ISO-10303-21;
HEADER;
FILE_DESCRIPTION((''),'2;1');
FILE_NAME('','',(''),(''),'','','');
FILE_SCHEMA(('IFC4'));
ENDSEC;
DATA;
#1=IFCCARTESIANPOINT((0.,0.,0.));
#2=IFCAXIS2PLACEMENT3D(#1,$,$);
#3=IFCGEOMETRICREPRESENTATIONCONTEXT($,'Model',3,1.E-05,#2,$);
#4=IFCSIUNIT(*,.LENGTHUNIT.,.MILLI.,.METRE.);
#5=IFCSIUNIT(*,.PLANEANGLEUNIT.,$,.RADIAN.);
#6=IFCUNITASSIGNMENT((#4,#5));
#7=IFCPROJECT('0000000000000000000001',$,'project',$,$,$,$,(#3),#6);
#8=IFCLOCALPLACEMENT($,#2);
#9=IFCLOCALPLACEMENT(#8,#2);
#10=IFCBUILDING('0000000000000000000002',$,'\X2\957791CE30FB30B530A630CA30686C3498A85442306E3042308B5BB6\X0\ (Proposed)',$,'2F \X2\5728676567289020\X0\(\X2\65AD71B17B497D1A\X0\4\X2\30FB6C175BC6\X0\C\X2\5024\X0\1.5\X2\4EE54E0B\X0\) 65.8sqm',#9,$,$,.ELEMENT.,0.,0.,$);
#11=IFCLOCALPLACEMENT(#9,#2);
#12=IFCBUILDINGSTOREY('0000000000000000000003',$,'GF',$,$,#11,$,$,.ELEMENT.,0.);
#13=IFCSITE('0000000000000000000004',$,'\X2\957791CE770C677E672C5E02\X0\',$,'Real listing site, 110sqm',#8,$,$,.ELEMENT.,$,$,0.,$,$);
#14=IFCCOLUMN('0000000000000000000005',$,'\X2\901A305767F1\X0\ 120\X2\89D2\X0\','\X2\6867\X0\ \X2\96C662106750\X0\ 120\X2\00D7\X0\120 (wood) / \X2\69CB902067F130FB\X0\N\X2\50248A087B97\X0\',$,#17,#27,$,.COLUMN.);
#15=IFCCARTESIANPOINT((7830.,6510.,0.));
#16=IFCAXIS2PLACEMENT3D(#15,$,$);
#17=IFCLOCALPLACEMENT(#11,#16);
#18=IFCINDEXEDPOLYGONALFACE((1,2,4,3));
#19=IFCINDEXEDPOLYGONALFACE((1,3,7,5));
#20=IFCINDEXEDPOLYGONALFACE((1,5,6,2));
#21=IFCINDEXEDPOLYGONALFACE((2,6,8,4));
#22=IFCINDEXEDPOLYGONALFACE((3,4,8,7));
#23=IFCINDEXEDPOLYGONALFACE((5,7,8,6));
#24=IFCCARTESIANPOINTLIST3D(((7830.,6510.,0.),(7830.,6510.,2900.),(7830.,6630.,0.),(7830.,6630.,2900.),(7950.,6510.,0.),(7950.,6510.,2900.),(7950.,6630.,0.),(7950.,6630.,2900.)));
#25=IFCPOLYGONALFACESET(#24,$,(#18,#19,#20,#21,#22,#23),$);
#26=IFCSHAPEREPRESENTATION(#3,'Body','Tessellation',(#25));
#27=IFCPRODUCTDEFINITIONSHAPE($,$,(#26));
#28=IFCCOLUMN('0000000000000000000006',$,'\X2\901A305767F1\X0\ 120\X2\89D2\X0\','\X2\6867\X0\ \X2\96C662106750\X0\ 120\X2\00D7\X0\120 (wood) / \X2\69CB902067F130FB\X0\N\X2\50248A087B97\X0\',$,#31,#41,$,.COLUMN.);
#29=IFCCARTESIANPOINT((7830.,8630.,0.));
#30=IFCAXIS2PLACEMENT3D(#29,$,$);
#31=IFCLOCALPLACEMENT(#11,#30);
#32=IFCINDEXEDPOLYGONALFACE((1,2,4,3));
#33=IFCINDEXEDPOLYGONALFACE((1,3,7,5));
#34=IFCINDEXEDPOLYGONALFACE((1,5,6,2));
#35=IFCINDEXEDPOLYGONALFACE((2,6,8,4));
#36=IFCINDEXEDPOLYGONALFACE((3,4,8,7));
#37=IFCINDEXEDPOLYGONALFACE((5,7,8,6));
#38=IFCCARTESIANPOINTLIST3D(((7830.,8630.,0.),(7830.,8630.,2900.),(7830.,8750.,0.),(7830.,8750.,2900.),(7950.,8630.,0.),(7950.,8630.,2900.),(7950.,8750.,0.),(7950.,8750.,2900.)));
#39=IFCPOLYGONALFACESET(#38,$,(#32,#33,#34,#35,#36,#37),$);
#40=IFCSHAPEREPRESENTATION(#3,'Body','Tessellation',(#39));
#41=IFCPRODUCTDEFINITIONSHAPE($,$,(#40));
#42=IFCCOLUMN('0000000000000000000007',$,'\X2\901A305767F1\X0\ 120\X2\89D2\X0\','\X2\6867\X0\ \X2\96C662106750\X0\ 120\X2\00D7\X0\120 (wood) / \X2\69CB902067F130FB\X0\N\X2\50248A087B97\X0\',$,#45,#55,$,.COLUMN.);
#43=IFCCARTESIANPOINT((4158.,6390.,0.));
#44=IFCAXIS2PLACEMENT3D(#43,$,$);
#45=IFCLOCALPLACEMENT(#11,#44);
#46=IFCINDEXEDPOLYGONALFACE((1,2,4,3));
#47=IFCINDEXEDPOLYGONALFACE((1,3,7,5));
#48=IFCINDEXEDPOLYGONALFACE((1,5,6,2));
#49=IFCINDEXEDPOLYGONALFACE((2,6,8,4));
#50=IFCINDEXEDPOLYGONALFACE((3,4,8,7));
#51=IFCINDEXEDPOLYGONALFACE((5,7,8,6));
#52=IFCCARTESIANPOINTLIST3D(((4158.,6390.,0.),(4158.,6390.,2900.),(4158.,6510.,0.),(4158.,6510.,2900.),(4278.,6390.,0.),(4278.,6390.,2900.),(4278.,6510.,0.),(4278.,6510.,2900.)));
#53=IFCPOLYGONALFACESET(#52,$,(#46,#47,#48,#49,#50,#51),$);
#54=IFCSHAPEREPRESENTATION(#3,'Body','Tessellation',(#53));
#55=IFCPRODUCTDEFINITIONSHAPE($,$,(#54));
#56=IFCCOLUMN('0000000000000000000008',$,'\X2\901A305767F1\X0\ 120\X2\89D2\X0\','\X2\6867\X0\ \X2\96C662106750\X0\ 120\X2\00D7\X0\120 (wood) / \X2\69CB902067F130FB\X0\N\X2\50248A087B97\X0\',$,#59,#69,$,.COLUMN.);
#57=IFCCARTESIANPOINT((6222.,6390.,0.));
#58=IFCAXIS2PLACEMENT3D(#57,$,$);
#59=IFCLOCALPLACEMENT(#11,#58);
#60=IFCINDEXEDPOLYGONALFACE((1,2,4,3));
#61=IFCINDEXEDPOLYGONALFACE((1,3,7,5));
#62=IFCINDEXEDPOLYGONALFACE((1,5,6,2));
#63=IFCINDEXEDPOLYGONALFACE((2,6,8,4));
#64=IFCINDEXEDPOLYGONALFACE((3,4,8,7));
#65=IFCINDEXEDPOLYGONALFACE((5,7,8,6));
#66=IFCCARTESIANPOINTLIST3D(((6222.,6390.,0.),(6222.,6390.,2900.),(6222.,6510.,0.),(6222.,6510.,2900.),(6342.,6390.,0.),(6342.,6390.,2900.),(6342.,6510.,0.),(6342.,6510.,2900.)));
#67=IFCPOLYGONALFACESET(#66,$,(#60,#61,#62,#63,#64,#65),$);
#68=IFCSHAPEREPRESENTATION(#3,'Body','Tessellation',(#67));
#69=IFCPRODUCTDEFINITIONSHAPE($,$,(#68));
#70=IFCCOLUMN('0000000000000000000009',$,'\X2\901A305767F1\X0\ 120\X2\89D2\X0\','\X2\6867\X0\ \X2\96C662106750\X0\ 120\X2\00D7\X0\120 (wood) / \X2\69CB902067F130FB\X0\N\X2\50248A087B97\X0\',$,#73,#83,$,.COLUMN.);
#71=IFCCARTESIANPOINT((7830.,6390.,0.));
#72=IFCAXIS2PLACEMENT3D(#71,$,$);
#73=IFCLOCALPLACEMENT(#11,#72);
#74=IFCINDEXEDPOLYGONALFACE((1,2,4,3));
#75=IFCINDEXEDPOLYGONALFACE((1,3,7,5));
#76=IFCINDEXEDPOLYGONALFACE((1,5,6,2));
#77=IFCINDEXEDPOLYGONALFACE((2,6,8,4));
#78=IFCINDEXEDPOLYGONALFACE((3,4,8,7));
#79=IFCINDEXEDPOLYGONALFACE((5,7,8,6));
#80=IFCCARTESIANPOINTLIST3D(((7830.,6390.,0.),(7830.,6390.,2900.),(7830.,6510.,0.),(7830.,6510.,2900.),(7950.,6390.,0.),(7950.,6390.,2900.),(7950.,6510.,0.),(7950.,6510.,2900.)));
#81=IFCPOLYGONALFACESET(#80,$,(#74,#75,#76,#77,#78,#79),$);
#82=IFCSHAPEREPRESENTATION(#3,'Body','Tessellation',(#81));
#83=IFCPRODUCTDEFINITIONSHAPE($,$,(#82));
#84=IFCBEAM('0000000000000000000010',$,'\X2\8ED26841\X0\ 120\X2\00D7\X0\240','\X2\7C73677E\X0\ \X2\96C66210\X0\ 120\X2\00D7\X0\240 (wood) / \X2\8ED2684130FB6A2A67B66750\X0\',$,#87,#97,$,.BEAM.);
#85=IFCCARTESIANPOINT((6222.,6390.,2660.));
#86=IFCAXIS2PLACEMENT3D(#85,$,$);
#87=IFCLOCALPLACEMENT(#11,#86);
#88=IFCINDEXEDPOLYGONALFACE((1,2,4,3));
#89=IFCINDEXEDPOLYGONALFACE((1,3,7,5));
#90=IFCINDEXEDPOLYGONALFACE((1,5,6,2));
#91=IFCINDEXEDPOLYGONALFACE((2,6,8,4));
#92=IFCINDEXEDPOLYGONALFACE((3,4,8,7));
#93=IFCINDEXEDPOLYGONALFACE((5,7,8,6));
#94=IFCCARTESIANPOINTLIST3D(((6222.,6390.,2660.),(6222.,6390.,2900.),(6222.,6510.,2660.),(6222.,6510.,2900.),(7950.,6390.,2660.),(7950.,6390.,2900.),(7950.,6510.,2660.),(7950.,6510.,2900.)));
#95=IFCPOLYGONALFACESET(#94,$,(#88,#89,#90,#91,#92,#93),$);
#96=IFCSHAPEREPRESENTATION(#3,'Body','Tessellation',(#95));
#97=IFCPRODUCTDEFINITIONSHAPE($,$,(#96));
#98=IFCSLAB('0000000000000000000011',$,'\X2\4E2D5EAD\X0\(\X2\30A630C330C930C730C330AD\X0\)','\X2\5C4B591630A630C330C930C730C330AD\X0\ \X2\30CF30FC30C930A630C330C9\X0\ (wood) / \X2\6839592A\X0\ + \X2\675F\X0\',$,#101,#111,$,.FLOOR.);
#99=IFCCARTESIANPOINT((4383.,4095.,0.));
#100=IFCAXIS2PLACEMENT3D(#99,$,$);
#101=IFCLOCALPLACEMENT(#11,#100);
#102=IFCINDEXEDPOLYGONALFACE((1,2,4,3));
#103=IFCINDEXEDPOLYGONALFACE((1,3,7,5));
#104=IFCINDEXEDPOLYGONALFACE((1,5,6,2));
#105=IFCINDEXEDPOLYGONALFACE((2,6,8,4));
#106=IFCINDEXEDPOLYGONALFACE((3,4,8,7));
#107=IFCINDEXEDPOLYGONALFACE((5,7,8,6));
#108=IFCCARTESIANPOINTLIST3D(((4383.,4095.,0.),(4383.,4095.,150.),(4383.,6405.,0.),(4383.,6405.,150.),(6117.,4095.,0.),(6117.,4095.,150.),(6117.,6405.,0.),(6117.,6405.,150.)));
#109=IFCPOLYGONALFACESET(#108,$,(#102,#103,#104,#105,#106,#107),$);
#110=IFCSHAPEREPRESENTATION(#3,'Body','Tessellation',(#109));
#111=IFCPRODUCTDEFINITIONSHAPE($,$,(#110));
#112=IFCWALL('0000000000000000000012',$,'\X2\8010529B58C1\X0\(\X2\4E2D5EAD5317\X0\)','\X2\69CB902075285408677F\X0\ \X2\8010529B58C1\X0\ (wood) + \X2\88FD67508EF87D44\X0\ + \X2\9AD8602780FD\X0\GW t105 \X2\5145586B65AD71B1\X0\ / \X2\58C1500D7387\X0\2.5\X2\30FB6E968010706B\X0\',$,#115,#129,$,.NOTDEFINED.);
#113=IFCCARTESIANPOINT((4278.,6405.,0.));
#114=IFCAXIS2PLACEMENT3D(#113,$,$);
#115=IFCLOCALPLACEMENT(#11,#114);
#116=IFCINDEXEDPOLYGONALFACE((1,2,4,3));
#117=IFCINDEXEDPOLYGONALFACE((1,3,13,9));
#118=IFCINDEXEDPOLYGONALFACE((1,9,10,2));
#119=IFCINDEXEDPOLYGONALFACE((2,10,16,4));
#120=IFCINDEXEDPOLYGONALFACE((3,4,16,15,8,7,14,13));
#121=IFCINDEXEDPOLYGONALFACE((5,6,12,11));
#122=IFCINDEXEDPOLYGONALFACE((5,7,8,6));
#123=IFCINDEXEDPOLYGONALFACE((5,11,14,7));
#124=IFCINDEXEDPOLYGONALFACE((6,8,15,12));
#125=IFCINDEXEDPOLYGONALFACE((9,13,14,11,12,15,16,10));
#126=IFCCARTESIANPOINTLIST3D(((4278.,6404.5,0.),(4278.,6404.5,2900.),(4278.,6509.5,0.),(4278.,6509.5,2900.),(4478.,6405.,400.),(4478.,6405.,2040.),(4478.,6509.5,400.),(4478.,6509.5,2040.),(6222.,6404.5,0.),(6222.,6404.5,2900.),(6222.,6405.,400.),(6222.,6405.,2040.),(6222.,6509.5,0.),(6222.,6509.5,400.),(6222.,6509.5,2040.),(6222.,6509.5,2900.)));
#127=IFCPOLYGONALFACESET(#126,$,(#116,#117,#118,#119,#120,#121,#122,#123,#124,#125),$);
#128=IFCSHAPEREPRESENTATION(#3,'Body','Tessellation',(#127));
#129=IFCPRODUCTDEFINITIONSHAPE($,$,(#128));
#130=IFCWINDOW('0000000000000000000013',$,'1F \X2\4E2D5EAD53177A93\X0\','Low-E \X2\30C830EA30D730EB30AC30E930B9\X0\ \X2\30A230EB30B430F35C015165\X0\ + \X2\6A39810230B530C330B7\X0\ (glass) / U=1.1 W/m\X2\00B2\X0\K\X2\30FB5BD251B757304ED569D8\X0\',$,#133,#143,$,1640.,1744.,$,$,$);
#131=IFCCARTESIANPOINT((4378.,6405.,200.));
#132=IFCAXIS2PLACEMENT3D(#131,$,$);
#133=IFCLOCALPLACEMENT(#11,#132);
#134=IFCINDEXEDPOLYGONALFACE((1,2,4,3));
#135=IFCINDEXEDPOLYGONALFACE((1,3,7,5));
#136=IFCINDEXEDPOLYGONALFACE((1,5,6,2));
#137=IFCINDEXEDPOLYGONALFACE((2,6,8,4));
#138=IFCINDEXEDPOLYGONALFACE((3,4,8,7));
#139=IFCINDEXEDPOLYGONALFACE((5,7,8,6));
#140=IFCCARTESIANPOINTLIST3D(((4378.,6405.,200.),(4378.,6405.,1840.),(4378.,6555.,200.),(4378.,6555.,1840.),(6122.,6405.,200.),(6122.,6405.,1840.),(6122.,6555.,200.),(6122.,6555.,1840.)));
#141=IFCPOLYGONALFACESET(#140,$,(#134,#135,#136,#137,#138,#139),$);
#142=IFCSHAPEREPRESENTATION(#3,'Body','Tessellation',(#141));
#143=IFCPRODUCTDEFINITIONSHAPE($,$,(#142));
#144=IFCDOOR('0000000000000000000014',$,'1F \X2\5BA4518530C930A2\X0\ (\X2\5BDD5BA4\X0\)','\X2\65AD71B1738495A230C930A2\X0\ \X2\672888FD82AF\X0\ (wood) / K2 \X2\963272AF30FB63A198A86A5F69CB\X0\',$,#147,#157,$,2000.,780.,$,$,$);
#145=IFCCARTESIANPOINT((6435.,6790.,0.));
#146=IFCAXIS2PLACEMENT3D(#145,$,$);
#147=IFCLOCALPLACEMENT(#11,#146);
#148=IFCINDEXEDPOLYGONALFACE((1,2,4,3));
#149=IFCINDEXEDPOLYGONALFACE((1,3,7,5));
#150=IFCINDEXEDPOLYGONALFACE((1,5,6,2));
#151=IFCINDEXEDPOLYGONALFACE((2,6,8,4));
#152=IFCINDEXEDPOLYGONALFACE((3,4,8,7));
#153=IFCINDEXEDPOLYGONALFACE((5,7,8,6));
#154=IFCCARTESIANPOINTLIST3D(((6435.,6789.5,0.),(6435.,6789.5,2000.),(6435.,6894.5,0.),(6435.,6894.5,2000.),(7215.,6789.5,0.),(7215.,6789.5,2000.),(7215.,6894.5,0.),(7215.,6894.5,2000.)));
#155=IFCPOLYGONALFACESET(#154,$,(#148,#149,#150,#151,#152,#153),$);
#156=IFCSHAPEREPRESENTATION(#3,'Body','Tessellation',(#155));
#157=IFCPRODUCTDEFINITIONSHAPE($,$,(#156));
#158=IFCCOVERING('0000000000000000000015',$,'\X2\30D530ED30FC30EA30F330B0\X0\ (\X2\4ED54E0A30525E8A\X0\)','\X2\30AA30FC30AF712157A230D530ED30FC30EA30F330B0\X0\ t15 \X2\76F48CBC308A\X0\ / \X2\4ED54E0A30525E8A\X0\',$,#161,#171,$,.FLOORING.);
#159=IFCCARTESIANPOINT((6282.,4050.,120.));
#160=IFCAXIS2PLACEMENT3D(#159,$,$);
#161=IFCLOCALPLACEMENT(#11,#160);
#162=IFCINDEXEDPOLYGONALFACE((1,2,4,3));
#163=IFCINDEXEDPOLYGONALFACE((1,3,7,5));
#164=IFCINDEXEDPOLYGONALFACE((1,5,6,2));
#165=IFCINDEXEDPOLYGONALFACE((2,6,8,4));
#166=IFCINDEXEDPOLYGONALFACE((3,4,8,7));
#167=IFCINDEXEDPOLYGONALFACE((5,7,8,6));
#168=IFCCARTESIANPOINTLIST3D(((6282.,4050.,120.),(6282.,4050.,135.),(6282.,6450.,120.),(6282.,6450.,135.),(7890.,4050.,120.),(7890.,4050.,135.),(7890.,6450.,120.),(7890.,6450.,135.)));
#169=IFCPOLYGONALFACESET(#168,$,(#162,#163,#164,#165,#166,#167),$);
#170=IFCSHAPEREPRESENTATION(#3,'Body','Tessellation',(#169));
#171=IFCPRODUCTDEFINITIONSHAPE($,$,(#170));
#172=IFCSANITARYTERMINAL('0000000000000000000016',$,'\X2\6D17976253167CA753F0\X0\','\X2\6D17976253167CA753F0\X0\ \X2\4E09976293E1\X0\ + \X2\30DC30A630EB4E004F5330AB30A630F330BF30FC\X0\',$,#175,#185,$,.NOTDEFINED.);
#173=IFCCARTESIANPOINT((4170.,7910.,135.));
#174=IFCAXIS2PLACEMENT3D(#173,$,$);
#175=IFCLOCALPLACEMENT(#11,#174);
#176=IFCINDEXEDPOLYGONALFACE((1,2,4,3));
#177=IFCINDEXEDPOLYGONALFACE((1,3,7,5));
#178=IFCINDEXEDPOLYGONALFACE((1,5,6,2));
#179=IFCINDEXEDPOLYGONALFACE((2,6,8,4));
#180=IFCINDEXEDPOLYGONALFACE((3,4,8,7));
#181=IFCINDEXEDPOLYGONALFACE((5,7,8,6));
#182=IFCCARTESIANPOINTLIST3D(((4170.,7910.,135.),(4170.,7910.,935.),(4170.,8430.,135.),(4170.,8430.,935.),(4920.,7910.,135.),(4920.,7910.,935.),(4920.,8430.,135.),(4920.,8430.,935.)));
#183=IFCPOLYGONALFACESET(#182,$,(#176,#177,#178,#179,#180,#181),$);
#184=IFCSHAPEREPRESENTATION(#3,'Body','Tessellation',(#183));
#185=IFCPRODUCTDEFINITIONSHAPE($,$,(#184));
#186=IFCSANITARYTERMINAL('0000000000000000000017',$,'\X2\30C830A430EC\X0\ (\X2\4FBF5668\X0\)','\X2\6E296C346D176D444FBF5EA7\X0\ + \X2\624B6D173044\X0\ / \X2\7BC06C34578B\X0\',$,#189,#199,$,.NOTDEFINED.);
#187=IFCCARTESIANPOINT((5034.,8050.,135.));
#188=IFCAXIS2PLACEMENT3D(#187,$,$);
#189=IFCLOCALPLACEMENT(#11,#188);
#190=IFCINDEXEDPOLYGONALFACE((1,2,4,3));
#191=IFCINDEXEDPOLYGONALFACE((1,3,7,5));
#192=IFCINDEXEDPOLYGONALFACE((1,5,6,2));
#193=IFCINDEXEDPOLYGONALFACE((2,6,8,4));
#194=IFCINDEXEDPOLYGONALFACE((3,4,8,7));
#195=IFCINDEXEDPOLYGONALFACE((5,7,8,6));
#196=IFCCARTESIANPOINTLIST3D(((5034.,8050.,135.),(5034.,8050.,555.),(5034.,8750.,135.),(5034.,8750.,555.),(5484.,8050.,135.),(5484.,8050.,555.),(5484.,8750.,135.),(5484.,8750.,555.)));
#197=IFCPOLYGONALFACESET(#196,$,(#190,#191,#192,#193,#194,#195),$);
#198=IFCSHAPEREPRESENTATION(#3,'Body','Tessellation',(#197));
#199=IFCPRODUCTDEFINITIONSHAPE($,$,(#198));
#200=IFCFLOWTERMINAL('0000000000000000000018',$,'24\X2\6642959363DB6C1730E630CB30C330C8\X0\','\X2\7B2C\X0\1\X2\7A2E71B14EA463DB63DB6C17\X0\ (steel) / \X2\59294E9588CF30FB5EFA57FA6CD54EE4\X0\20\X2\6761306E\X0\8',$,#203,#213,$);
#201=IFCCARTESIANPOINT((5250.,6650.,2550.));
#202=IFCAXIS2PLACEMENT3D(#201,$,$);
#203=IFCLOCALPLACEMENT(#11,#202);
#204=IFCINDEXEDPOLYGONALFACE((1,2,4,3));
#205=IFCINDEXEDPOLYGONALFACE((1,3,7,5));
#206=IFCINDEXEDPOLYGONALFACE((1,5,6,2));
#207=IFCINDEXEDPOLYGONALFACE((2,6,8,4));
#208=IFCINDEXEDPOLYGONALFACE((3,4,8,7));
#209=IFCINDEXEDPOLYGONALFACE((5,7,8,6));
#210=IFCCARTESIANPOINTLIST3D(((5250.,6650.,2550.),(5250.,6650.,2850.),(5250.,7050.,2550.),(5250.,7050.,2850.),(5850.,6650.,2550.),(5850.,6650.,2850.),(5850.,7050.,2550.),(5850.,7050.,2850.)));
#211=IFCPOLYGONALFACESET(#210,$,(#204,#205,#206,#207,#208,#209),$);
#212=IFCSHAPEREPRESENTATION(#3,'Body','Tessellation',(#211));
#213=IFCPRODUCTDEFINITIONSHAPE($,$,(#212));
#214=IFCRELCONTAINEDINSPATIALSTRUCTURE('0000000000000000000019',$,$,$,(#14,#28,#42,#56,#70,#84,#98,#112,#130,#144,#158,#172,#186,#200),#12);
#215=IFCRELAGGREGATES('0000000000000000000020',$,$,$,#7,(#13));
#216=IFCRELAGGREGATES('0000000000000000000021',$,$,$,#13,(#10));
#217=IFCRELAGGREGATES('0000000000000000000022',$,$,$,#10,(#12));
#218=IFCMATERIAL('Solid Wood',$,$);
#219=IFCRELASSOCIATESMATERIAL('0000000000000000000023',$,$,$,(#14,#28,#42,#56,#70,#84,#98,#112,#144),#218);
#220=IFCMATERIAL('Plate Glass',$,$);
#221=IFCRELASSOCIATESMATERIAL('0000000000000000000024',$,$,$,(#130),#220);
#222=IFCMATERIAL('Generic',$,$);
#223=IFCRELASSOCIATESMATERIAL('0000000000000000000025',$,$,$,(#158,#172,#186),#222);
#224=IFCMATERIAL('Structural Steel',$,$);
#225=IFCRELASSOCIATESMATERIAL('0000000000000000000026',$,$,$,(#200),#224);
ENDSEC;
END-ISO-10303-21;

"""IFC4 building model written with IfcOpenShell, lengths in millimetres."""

from ifc_helpers import new_model, si_unit, frame, frame_2d, origin, place, context, project, spatial, rectangle, extrude, material, element, fill, save


model = new_model("IFC4")

# Units and contexts
model_context = context("Model", 3, precision=1e-05, world=origin())
ifc_project = project(units=[si_unit("LENGTHUNIT", "METRE", prefix="MILLI"), si_unit("PLANEANGLEUNIT", "RADIAN")], contexts=[model_context])

# Site, building, storey
site_placement = place(None, origin())
site = spatial("IfcSite", under=ifc_project, at=site_placement, Name="長野県松本市", ObjectType="Real listing site, 110sqm", CompositionType="ELEMENT", RefElevation=0.0)
building_placement = place(site_placement, origin())
building = spatial("IfcBuilding", under=site, at=building_placement, Name="長野・サウナと水風呂のある家 (Proposed)", ObjectType="2F 在来木造(断熱等級4・気密C値1.5以下) 65.8sqm", CompositionType="ELEMENT", ElevationOfRefHeight=0.0, ElevationOfTerrain=0.0)
storey_placement = place(building_placement, origin())
storey = spatial("IfcBuildingStorey", under=building, at=storey_placement, Name="GF", CompositionType="ELEMENT", Elevation=0.0)

# Columns
ifc_material_1 = material(Name="Solid Wood")
column_1_placement = place(storey_placement, frame((7830.0, 6510.0, 0.0)))
element("IfcColumn", 1, at=column_1_placement, inside=storey, material=ifc_material_1, Name="通し柱 120角", Description="桧 集成材 120×120 (wood) / 構造柱・N値計算", PredefinedType="COLUMN", context=model_context, shape_type="SweptSolid", body=[
    extrude(rectangle(XDim=120.0, YDim=120.0, at=frame_2d((60.0, 60.0))), frame((7830.0, 6510.0, 0.0)), (0.0, 0.0, 1.0), 2900.0),
])
column_2_placement = place(storey_placement, frame((7830.0, 8630.0, 0.0)))
element("IfcColumn", 2, at=column_2_placement, inside=storey, material=ifc_material_1, Name="通し柱 120角", Description="桧 集成材 120×120 (wood) / 構造柱・N値計算", PredefinedType="COLUMN", context=model_context, shape_type="SweptSolid", body=[
    extrude(rectangle(XDim=120.0, YDim=120.0, at=frame_2d((60.0, 60.0))), frame((7830.0, 8630.0, 0.0)), (0.0, 0.0, 1.0), 2900.0),
])
column_3_placement = place(storey_placement, frame((4158.0, 6390.0, 0.0)))
element("IfcColumn", 3, at=column_3_placement, inside=storey, material=ifc_material_1, Name="通し柱 120角", Description="桧 集成材 120×120 (wood) / 構造柱・N値計算", PredefinedType="COLUMN", context=model_context, shape_type="SweptSolid", body=[
    extrude(rectangle(XDim=120.0, YDim=120.0, at=frame_2d((60.0, 60.0))), frame((4158.0, 6390.0, 0.0)), (0.0, 0.0, 1.0), 2900.0),
])
column_4_placement = place(storey_placement, frame((6222.0, 6390.0, 0.0)))
element("IfcColumn", 4, at=column_4_placement, inside=storey, material=ifc_material_1, Name="通し柱 120角", Description="桧 集成材 120×120 (wood) / 構造柱・N値計算", PredefinedType="COLUMN", context=model_context, shape_type="SweptSolid", body=[
    extrude(rectangle(XDim=120.0, YDim=120.0, at=frame_2d((60.0, 60.0))), frame((6222.0, 6390.0, 0.0)), (0.0, 0.0, 1.0), 2900.0),
])
column_5_placement = place(storey_placement, frame((7830.0, 6390.0, 0.0)))
element("IfcColumn", 5, at=column_5_placement, inside=storey, material=ifc_material_1, Name="通し柱 120角", Description="桧 集成材 120×120 (wood) / 構造柱・N値計算", PredefinedType="COLUMN", context=model_context, shape_type="SweptSolid", body=[
    extrude(rectangle(XDim=120.0, YDim=120.0, at=frame_2d((60.0, 60.0))), frame((7830.0, 6390.0, 0.0)), (0.0, 0.0, 1.0), 2900.0),
])

# Beam
beam_1_placement = place(storey_placement, frame((6222.0, 6390.0, 2660.0)))
element("IfcBeam", 6, at=beam_1_placement, inside=storey, material=ifc_material_1, Name="軒桁 120×240", Description="米松 集成 120×240 (wood) / 軒桁・横架材", PredefinedType="BEAM", context=model_context, shape_type="SweptSolid", body=[
    extrude(rectangle(XDim=1728.0, YDim=120.0, at=frame_2d((864.0, 60.0))), frame((6222.0, 6390.0, 2660.0)), (0.0, 0.0, 1.0), 240.0),
])

# Slab
slab_placement = place(storey_placement, frame((4383.0, 4095.0, 0.0)))
element("IfcSlab", 7, at=slab_placement, inside=storey, material=ifc_material_1, Name="中庭(ウッドデッキ)", Description="屋外ウッドデッキ ハードウッド (wood) / 根太 + 束", PredefinedType="FLOOR", context=model_context, shape_type="SweptSolid", body=[
    extrude(rectangle(XDim=1734.0, YDim=2310.0, at=frame_2d((867.0, 1155.0))), frame((4383.0, 4095.0, 0.0)), (0.0, 0.0, 1.0), 150.0),
])

# Wall, opening, window
wall_1_placement = place(storey_placement, frame((4278.0, 6405.0, 0.0)))
wall_1 = element("IfcWall", 8, at=wall_1_placement, inside=storey, material=ifc_material_1, Name="耐力壁(中庭北)", Description="構造用合板 耐力壁 (wood) + 製材軸組 + 高性能GW t105 充填断熱 / 壁倍率2.5・準耐火", PredefinedType="NOTDEFINED", context=model_context, shape_type="SweptSolid", body=[
    extrude(rectangle(XDim=1944.0, YDim=105.0, at=frame_2d((972.0, 52.0))), frame((4278.0, 6405.0, 0.0)), (0.0, 0.0, 1.0), 2900.0),
])
opening_placement = place(storey_placement, frame((4378.0, 6405.0, 200.0)))
opening = element("IfcOpeningElement", 9, at=opening_placement, cuts=wall_1, PredefinedType="NOTDEFINED", context=model_context, shape_type="SweptSolid", body=[
    extrude(rectangle(XDim=1744.0, YDim=150.0, at=frame_2d((872.0, 75.0))), frame((4378.0, 6405.0, 200.0)), (0.0, 0.0, 1.0), 1640.0),
])
ifc_material_2 = material(Name="Plate Glass")
window_placement = place(storey_placement, frame((4378.0, 6405.0, 200.0)))
window = element("IfcWindow", 10, at=window_placement, inside=storey, material=ifc_material_2, Name="1F 中庭北窓", Description="Low-E トリプルガラス アルゴン封入 + 樹脂サッシ (glass) / U=1.1 W/m²K・寒冷地仕様", OverallHeight=1640.0, OverallWidth=1744.0, context=model_context, shape_type="SweptSolid", body=[
    extrude(rectangle(XDim=1744.0, YDim=150.0, at=frame_2d((872.0, 75.0))), frame((4378.0, 6405.0, 200.0)), (0.0, 0.0, 1.0), 1640.0),
])
fill(opening, window)

# Door
door_placement = place(storey_placement, frame((6435.0, 6790.0, 0.0)))
element("IfcDoor", 11, at=door_placement, inside=storey, material=ifc_material_1, Name="1F 室内ドア (寝室)", Description="断熱玄関ドア 木製芯 (wood) / K2 防犯・採風機構", OverallHeight=2000.0, OverallWidth=780.0, context=model_context, shape_type="SweptSolid", body=[
    extrude(rectangle(XDim=780.0, YDim=105.0, at=frame_2d((390.0, 52.0))), frame((6435.0, 6790.0, 0.0)), (0.0, 0.0, 1.0), 2000.0),
])

# Covering
ifc_material_3 = material(Name="Generic")
covering_placement = place(storey_placement, frame((6282.0, 4050.0, 120.0)))
element("IfcCovering", 12, at=covering_placement, inside=storey, material=ifc_material_3, Name="フローリング (仕上げ床)", Description="オーク無垢フローリング t15 直貼り / 仕上げ床", PredefinedType="FLOORING", context=model_context, shape_type="SweptSolid", body=[
    extrude(rectangle(XDim=1608.0, YDim=2400.0, at=frame_2d((804.0, 1200.0))), frame((6282.0, 4050.0, 120.0)), (0.0, 0.0, 1.0), 15.0),
])

# Sanitary terminals
sanitary_terminal_1_placement = place(storey_placement, frame((4170.0, 7910.0, 135.0)))
element("IfcSanitaryTerminal", 13, at=sanitary_terminal_1_placement, inside=storey, material=ifc_material_3, Name="洗面化粧台", Description="洗面化粧台 三面鏡 + ボウル一体カウンター", PredefinedType="NOTDEFINED", context=model_context, shape_type="SweptSolid", body=[
    extrude(rectangle(XDim=750.0, YDim=520.0, at=frame_2d((375.0, 260.0))), frame((4170.0, 7910.0, 135.0)), (0.0, 0.0, 1.0), 800.0),
])
sanitary_terminal_2_placement = place(storey_placement, frame((5034.0, 8050.0, 135.0)))
element("IfcSanitaryTerminal", 14, at=sanitary_terminal_2_placement, inside=storey, material=ifc_material_3, Name="トイレ (便器)", Description="温水洗浄便座 + 手洗い / 節水型", PredefinedType="NOTDEFINED", context=model_context, shape_type="SweptSolid", body=[
    extrude(rectangle(XDim=450.0, YDim=700.0, at=frame_2d((225.0, 350.0))), frame((5034.0, 8050.0, 135.0)), (0.0, 0.0, 1.0), 420.0),
])

# Flow terminal
ifc_material_4 = material(Name="Structural Steel")
flow_terminal_placement = place(storey_placement, frame((5250.0, 6650.0, 2550.0)))
element("IfcFlowTerminal", 15, at=flow_terminal_placement, inside=storey, material=ifc_material_4, Name="24時間換気ユニット", Description="第1種熱交換換気 (steel) / 天井裏・建基法令20条の8", context=model_context, shape_type="SweptSolid", body=[
    extrude(rectangle(XDim=600.0, YDim=400.0, at=frame_2d((300.0, 200.0))), frame((5250.0, 6650.0, 2550.0)), (0.0, 0.0, 1.0), 300.0),
])

save(model, "model.ifc")
